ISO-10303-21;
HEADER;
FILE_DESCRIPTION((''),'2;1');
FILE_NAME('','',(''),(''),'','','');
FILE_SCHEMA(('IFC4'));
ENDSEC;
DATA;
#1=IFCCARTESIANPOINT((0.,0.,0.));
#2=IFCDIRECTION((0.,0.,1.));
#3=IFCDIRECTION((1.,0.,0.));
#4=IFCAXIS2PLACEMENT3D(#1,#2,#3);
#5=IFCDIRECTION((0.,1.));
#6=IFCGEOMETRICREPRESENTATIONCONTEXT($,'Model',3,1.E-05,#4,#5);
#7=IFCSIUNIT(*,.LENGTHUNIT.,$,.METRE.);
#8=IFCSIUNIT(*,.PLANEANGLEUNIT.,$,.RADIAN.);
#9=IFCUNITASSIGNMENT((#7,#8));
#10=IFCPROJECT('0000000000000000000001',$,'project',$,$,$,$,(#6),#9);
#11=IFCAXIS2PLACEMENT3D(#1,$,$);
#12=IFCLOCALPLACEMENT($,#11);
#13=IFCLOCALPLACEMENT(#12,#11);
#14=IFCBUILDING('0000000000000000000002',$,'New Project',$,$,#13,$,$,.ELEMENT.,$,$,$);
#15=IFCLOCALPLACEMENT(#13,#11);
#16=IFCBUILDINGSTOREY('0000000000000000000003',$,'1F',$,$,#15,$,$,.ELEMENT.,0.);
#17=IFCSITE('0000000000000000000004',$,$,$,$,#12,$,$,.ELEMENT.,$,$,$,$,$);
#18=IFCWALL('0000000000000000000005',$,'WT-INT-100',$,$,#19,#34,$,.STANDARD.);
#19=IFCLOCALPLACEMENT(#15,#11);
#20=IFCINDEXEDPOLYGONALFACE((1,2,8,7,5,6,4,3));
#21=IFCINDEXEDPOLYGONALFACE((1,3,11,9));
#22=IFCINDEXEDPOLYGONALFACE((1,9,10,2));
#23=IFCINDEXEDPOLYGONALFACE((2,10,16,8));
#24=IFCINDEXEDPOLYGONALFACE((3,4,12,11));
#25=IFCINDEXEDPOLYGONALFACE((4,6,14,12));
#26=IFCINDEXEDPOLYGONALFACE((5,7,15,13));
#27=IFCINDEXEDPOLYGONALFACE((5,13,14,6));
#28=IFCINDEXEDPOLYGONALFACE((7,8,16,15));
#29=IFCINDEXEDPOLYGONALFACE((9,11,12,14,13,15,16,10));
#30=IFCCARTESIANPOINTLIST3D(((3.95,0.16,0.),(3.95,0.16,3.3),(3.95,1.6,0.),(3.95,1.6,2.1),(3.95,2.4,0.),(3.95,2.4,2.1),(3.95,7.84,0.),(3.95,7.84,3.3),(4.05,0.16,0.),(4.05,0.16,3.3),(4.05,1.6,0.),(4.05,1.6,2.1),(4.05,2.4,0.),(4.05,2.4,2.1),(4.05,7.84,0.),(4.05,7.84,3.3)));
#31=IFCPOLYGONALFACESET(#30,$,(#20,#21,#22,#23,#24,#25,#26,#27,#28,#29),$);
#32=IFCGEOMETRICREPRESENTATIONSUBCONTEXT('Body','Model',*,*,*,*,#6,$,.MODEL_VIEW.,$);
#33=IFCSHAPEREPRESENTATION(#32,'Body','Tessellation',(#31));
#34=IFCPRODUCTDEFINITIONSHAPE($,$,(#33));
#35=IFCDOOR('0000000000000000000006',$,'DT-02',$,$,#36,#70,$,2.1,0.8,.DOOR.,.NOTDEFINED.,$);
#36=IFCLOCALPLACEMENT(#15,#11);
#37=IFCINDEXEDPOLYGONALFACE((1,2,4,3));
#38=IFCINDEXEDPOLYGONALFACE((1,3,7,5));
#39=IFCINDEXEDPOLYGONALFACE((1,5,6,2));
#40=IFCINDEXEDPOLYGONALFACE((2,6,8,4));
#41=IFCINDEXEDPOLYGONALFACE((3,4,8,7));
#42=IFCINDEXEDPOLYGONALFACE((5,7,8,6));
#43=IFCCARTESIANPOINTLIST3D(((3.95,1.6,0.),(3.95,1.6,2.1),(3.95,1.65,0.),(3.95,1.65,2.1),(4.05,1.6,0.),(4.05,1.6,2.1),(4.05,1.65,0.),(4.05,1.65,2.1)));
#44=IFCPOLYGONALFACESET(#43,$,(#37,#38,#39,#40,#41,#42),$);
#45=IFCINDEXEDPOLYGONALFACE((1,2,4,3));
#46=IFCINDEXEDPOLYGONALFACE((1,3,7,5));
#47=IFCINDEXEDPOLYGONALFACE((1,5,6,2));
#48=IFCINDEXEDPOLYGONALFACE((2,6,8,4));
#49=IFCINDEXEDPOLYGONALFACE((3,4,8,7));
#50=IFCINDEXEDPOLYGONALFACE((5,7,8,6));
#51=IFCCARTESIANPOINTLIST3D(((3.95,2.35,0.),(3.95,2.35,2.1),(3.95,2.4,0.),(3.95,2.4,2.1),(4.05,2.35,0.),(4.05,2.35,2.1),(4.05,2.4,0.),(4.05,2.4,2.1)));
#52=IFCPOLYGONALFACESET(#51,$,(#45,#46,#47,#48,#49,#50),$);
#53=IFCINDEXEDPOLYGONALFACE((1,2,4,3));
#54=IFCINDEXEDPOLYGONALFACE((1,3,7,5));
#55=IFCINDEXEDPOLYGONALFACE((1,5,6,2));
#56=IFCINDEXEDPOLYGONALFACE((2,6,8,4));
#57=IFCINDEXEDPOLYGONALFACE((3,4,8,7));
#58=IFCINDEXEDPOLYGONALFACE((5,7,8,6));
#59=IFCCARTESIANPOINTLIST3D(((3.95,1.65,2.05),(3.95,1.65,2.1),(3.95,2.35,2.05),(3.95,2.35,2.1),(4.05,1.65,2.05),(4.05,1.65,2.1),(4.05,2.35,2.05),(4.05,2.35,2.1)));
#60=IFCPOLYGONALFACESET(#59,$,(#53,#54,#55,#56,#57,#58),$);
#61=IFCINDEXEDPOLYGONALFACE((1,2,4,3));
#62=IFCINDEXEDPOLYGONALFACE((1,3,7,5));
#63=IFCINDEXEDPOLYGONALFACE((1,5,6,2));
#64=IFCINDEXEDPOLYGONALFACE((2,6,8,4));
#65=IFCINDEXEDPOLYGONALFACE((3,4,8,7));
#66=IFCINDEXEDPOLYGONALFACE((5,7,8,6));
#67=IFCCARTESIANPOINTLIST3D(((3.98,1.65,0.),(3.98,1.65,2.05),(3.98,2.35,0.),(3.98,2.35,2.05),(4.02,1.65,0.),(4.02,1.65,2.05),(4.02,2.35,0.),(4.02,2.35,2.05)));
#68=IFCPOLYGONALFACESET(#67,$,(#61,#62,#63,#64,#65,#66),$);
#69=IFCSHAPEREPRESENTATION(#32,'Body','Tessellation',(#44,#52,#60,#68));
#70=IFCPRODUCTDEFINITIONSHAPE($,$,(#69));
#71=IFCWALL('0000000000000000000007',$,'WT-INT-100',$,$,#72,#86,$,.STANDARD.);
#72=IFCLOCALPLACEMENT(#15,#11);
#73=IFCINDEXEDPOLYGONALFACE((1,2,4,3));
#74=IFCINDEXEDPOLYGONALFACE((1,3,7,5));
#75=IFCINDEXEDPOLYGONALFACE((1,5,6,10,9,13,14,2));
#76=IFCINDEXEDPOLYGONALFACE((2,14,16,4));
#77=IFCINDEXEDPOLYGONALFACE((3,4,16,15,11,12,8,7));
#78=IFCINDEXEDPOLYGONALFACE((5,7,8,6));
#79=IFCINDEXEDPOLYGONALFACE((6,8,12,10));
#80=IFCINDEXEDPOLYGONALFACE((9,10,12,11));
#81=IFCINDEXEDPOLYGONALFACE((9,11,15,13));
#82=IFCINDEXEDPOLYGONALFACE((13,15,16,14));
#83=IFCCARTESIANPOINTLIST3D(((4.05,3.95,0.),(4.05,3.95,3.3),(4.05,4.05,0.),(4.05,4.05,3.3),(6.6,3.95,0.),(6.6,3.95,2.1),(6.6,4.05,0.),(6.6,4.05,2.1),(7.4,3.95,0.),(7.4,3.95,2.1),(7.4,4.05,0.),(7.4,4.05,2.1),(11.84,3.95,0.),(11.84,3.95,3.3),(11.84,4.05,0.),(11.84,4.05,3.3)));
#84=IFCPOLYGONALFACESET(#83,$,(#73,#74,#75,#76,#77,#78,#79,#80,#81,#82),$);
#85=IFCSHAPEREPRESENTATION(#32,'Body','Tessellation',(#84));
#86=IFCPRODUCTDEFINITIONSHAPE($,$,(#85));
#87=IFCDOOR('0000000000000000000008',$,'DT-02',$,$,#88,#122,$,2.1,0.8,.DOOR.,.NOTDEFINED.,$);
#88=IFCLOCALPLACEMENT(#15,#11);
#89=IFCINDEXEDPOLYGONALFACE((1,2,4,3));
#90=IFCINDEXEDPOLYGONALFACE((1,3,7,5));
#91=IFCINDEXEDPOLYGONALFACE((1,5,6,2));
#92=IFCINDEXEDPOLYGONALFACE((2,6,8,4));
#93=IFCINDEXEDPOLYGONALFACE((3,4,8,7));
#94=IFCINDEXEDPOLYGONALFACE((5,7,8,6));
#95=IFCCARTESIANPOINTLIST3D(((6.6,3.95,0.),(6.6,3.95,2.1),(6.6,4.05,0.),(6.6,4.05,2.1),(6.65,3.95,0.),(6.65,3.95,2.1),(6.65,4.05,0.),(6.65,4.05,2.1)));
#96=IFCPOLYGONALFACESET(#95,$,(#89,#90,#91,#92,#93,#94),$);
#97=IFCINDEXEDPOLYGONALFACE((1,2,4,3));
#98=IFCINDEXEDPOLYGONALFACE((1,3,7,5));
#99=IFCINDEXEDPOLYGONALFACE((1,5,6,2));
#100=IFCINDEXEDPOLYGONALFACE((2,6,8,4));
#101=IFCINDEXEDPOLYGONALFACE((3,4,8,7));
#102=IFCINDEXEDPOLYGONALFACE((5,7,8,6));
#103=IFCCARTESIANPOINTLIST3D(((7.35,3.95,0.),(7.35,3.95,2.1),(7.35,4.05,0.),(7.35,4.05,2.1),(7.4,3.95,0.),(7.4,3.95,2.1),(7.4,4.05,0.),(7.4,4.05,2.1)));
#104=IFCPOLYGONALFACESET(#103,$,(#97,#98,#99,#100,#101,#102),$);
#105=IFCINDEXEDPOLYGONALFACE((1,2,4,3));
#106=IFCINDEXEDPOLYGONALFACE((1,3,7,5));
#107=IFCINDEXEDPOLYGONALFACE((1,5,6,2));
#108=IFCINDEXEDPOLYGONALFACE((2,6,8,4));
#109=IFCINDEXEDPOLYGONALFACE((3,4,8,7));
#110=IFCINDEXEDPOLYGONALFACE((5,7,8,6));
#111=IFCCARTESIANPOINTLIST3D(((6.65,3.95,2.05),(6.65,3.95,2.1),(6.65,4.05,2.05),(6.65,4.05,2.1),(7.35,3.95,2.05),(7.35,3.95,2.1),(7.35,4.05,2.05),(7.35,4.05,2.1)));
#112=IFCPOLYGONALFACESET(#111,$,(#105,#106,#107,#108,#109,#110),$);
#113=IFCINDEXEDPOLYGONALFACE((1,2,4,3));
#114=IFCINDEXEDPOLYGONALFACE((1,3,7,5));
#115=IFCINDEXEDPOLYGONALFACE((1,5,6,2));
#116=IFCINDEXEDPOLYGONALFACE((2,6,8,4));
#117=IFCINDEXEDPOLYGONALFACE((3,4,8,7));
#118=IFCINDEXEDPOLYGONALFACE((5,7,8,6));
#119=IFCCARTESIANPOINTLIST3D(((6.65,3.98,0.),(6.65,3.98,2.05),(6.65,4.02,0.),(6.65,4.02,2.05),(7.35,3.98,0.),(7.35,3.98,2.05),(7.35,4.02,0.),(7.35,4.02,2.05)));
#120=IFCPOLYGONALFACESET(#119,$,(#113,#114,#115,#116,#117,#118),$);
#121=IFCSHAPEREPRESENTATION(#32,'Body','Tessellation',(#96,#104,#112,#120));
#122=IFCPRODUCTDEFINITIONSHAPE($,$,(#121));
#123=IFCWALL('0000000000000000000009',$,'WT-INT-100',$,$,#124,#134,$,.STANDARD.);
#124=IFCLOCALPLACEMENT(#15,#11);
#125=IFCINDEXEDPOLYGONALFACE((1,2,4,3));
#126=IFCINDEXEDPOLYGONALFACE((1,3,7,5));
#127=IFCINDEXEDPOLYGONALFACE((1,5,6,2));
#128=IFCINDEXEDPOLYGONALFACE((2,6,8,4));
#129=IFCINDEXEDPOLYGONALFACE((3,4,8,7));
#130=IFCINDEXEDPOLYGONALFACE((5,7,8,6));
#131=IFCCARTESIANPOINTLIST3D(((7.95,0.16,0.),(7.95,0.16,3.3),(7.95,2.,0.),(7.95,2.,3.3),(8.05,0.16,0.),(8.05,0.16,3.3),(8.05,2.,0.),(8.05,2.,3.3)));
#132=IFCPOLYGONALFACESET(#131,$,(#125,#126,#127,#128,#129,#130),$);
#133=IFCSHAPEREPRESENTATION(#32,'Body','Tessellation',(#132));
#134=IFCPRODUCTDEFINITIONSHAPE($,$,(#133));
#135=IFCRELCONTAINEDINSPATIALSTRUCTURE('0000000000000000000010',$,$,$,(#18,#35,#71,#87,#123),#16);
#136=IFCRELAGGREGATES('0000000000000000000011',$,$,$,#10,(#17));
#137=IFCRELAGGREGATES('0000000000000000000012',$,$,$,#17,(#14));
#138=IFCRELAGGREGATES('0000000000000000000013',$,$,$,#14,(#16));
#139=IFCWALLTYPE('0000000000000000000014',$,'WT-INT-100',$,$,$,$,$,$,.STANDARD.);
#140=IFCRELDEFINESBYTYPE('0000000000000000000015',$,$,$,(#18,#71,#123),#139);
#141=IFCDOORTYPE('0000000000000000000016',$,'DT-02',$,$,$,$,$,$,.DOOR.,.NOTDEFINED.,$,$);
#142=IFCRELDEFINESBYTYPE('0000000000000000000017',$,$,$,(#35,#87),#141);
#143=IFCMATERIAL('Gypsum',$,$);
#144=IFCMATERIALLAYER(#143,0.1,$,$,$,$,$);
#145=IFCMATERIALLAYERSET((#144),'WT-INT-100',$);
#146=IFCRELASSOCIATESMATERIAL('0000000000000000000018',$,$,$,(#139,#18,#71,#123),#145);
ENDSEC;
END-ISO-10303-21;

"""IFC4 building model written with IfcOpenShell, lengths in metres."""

from ifc_helpers import new_model, si_unit, direction, frame, frame_2d, origin, origin_with_axes, place, context, subcontext, project, spatial, polyline, rectangle, outline, extrude, material, layer, layer_set, layer_usage, type_object, element, fill, save


model = new_model("IFC4")

# Units and contexts
model_context = context("Model", 3, precision=1e-05, world=origin_with_axes(), true_north=direction((0.0, 1.0)))
body_context = subcontext(model_context, "Body", "Model", "MODEL_VIEW")
ifc_project = project(units=[si_unit("LENGTHUNIT", "METRE"), si_unit("PLANEANGLEUNIT", "RADIAN")], contexts=[model_context])

# Site, building, storey
site_placement = place(None, origin())
site = spatial("IfcSite", under=ifc_project, at=site_placement, CompositionType="ELEMENT")
building_placement = place(site_placement, origin())
building = spatial("IfcBuilding", under=site, at=building_placement, Name="New Project", CompositionType="ELEMENT")
storey_placement = place(building_placement, origin())
storey = spatial("IfcBuildingStorey", under=building, at=storey_placement, Name="1F", CompositionType="ELEMENT", Elevation=0.0)

# Walls, openings, doors
ifc_material_1 = material(Name="Gypsum")
ifc_layer_1 = layer(ifc_material_1, 0.1)
ifc_layer_set_1 = layer_set([ifc_layer_1], Name="WT-INT-100")
ifc_layer_usage_1 = layer_usage(ifc_layer_set_1, "AXIS2", "NEGATIVE", 0.05)
wall_type_1 = type_object("IfcWallType", Name="WT-INT-100", PredefinedType="STANDARD", material=ifc_layer_set_1)
wall_1_placement = place(storey_placement, frame((4.0, 0.16, 0.0), z_axis=(0.0, 0.0, 1.0), x_axis=(0.0, 1.0, 0.0)))
wall_1 = element("IfcWall", 1, at=wall_1_placement, inside=storey, type_object=wall_type_1, material=ifc_layer_usage_1, Name="WT-INT-100", PredefinedType="STANDARD", context=body_context, shape_type="SweptSolid", body=[
    extrude(outline(polyline([(0.0, -0.05), (7.68, -0.05), (7.68, 0.05), (0.0, 0.05), (0.0, -0.05)])), origin(), (0.0, 0.0, 1.0), 3.3),
])
opening_1_placement = place(wall_1_placement, frame((1.44, 0.0, 0.0)))
opening_1 = element("IfcOpeningElement", 2, at=opening_1_placement, cuts=wall_1, PredefinedType="OPENING", context=body_context, shape_type="SweptSolid", body=[
    extrude(rectangle(XDim=0.8, YDim=0.2, at=frame_2d((0.4, 0.0))), origin(), (0.0, 0.0, 1.0), 2.1),
])
door_type_1 = type_object("IfcDoorType", Name="DT-02", OperationType="NOTDEFINED", PredefinedType="DOOR")
door_1_placement = place(opening_1_placement, origin())
door_1 = element("IfcDoor", 3, at=door_1_placement, inside=storey, type_object=door_type_1, Name="DT-02", OperationType="NOTDEFINED", OverallHeight=2.1, OverallWidth=0.8, PredefinedType="DOOR", context=body_context, shape_type="SweptSolid", body=[
    extrude(outline(polyline([(0.0, -0.05), (0.05, -0.05), (0.05, 0.05), (0.0, 0.05), (0.0, -0.05)])), origin(), (0.0, 0.0, 1.0), 2.1),
    extrude(outline(polyline([(0.75, -0.05), (0.8, -0.05), (0.8, 0.05), (0.75, 0.05), (0.75, -0.05)])), origin(), (0.0, 0.0, 1.0), 2.1),
    extrude(outline(polyline([(0.05, -0.05), (0.75, -0.05), (0.75, 0.05), (0.05, 0.05), (0.05, -0.05)])), frame((0.0, 0.0, 2.05)), (0.0, 0.0, 1.0), 0.05),
    extrude(outline(polyline([(0.05, -0.02), (0.75, -0.02), (0.75, 0.02), (0.05, 0.02), (0.05, -0.02)])), origin(), (0.0, 0.0, 1.0), 2.05),
])
fill(opening_1, door_1)
wall_2_placement = place(storey_placement, frame((4.05, 4.0, 0.0)))
wall_2 = element("IfcWall", 4, at=wall_2_placement, inside=storey, type_object=wall_type_1, material=ifc_layer_usage_1, Name="WT-INT-100", PredefinedType="STANDARD", context=body_context, shape_type="SweptSolid", body=[
    extrude(outline(polyline([(0.0, -0.05), (7.79, -0.05), (7.79, 0.05), (0.0, 0.05), (0.0, -0.05)])), origin(), (0.0, 0.0, 1.0), 3.3),
])
opening_2_placement = place(wall_2_placement, frame((2.55, 0.0, 0.0)))
opening_2 = element("IfcOpeningElement", 5, at=opening_2_placement, cuts=wall_2, PredefinedType="OPENING", context=body_context, shape_type="SweptSolid", body=[
    extrude(rectangle(XDim=0.8, YDim=0.2, at=frame_2d((0.4, 0.0))), origin(), (0.0, 0.0, 1.0), 2.1),
])
door_2_placement = place(opening_2_placement, origin())
door_2 = element("IfcDoor", 6, at=door_2_placement, inside=storey, type_object=door_type_1, Name="DT-02", OperationType="NOTDEFINED", OverallHeight=2.1, OverallWidth=0.8, PredefinedType="DOOR", context=body_context, shape_type="SweptSolid", body=[
    extrude(outline(polyline([(0.0, -0.05), (0.05, -0.05), (0.05, 0.05), (0.0, 0.05), (0.0, -0.05)])), origin(), (0.0, 0.0, 1.0), 2.1),
    extrude(outline(polyline([(0.75, -0.05), (0.8, -0.05), (0.8, 0.05), (0.75, 0.05), (0.75, -0.05)])), origin(), (0.0, 0.0, 1.0), 2.1),
    extrude(outline(polyline([(0.05, -0.05), (0.75, -0.05), (0.75, 0.05), (0.05, 0.05), (0.05, -0.05)])), frame((0.0, 0.0, 2.05)), (0.0, 0.0, 1.0), 0.05),
    extrude(outline(polyline([(0.05, -0.02), (0.75, -0.02), (0.75, 0.02), (0.05, 0.02), (0.05, -0.02)])), origin(), (0.0, 0.0, 1.0), 2.05),
])
fill(opening_2, door_2)

# Wall
wall_3_placement = place(storey_placement, frame((8.0, 0.16, 0.0), z_axis=(0.0, 0.0, 1.0), x_axis=(0.0, 1.0, 0.0)))
element("IfcWall", 7, at=wall_3_placement, inside=storey, type_object=wall_type_1, material=ifc_layer_usage_1, Name="WT-INT-100", PredefinedType="STANDARD", context=body_context, shape_type="SweptSolid", body=[
    extrude(outline(polyline([(0.0, -0.05), (1.84, -0.05), (1.84, 0.05), (0.0, 0.05), (0.0, -0.05)])), origin(), (0.0, 0.0, 1.0), 3.3),
])

save(model, "model.ifc")
